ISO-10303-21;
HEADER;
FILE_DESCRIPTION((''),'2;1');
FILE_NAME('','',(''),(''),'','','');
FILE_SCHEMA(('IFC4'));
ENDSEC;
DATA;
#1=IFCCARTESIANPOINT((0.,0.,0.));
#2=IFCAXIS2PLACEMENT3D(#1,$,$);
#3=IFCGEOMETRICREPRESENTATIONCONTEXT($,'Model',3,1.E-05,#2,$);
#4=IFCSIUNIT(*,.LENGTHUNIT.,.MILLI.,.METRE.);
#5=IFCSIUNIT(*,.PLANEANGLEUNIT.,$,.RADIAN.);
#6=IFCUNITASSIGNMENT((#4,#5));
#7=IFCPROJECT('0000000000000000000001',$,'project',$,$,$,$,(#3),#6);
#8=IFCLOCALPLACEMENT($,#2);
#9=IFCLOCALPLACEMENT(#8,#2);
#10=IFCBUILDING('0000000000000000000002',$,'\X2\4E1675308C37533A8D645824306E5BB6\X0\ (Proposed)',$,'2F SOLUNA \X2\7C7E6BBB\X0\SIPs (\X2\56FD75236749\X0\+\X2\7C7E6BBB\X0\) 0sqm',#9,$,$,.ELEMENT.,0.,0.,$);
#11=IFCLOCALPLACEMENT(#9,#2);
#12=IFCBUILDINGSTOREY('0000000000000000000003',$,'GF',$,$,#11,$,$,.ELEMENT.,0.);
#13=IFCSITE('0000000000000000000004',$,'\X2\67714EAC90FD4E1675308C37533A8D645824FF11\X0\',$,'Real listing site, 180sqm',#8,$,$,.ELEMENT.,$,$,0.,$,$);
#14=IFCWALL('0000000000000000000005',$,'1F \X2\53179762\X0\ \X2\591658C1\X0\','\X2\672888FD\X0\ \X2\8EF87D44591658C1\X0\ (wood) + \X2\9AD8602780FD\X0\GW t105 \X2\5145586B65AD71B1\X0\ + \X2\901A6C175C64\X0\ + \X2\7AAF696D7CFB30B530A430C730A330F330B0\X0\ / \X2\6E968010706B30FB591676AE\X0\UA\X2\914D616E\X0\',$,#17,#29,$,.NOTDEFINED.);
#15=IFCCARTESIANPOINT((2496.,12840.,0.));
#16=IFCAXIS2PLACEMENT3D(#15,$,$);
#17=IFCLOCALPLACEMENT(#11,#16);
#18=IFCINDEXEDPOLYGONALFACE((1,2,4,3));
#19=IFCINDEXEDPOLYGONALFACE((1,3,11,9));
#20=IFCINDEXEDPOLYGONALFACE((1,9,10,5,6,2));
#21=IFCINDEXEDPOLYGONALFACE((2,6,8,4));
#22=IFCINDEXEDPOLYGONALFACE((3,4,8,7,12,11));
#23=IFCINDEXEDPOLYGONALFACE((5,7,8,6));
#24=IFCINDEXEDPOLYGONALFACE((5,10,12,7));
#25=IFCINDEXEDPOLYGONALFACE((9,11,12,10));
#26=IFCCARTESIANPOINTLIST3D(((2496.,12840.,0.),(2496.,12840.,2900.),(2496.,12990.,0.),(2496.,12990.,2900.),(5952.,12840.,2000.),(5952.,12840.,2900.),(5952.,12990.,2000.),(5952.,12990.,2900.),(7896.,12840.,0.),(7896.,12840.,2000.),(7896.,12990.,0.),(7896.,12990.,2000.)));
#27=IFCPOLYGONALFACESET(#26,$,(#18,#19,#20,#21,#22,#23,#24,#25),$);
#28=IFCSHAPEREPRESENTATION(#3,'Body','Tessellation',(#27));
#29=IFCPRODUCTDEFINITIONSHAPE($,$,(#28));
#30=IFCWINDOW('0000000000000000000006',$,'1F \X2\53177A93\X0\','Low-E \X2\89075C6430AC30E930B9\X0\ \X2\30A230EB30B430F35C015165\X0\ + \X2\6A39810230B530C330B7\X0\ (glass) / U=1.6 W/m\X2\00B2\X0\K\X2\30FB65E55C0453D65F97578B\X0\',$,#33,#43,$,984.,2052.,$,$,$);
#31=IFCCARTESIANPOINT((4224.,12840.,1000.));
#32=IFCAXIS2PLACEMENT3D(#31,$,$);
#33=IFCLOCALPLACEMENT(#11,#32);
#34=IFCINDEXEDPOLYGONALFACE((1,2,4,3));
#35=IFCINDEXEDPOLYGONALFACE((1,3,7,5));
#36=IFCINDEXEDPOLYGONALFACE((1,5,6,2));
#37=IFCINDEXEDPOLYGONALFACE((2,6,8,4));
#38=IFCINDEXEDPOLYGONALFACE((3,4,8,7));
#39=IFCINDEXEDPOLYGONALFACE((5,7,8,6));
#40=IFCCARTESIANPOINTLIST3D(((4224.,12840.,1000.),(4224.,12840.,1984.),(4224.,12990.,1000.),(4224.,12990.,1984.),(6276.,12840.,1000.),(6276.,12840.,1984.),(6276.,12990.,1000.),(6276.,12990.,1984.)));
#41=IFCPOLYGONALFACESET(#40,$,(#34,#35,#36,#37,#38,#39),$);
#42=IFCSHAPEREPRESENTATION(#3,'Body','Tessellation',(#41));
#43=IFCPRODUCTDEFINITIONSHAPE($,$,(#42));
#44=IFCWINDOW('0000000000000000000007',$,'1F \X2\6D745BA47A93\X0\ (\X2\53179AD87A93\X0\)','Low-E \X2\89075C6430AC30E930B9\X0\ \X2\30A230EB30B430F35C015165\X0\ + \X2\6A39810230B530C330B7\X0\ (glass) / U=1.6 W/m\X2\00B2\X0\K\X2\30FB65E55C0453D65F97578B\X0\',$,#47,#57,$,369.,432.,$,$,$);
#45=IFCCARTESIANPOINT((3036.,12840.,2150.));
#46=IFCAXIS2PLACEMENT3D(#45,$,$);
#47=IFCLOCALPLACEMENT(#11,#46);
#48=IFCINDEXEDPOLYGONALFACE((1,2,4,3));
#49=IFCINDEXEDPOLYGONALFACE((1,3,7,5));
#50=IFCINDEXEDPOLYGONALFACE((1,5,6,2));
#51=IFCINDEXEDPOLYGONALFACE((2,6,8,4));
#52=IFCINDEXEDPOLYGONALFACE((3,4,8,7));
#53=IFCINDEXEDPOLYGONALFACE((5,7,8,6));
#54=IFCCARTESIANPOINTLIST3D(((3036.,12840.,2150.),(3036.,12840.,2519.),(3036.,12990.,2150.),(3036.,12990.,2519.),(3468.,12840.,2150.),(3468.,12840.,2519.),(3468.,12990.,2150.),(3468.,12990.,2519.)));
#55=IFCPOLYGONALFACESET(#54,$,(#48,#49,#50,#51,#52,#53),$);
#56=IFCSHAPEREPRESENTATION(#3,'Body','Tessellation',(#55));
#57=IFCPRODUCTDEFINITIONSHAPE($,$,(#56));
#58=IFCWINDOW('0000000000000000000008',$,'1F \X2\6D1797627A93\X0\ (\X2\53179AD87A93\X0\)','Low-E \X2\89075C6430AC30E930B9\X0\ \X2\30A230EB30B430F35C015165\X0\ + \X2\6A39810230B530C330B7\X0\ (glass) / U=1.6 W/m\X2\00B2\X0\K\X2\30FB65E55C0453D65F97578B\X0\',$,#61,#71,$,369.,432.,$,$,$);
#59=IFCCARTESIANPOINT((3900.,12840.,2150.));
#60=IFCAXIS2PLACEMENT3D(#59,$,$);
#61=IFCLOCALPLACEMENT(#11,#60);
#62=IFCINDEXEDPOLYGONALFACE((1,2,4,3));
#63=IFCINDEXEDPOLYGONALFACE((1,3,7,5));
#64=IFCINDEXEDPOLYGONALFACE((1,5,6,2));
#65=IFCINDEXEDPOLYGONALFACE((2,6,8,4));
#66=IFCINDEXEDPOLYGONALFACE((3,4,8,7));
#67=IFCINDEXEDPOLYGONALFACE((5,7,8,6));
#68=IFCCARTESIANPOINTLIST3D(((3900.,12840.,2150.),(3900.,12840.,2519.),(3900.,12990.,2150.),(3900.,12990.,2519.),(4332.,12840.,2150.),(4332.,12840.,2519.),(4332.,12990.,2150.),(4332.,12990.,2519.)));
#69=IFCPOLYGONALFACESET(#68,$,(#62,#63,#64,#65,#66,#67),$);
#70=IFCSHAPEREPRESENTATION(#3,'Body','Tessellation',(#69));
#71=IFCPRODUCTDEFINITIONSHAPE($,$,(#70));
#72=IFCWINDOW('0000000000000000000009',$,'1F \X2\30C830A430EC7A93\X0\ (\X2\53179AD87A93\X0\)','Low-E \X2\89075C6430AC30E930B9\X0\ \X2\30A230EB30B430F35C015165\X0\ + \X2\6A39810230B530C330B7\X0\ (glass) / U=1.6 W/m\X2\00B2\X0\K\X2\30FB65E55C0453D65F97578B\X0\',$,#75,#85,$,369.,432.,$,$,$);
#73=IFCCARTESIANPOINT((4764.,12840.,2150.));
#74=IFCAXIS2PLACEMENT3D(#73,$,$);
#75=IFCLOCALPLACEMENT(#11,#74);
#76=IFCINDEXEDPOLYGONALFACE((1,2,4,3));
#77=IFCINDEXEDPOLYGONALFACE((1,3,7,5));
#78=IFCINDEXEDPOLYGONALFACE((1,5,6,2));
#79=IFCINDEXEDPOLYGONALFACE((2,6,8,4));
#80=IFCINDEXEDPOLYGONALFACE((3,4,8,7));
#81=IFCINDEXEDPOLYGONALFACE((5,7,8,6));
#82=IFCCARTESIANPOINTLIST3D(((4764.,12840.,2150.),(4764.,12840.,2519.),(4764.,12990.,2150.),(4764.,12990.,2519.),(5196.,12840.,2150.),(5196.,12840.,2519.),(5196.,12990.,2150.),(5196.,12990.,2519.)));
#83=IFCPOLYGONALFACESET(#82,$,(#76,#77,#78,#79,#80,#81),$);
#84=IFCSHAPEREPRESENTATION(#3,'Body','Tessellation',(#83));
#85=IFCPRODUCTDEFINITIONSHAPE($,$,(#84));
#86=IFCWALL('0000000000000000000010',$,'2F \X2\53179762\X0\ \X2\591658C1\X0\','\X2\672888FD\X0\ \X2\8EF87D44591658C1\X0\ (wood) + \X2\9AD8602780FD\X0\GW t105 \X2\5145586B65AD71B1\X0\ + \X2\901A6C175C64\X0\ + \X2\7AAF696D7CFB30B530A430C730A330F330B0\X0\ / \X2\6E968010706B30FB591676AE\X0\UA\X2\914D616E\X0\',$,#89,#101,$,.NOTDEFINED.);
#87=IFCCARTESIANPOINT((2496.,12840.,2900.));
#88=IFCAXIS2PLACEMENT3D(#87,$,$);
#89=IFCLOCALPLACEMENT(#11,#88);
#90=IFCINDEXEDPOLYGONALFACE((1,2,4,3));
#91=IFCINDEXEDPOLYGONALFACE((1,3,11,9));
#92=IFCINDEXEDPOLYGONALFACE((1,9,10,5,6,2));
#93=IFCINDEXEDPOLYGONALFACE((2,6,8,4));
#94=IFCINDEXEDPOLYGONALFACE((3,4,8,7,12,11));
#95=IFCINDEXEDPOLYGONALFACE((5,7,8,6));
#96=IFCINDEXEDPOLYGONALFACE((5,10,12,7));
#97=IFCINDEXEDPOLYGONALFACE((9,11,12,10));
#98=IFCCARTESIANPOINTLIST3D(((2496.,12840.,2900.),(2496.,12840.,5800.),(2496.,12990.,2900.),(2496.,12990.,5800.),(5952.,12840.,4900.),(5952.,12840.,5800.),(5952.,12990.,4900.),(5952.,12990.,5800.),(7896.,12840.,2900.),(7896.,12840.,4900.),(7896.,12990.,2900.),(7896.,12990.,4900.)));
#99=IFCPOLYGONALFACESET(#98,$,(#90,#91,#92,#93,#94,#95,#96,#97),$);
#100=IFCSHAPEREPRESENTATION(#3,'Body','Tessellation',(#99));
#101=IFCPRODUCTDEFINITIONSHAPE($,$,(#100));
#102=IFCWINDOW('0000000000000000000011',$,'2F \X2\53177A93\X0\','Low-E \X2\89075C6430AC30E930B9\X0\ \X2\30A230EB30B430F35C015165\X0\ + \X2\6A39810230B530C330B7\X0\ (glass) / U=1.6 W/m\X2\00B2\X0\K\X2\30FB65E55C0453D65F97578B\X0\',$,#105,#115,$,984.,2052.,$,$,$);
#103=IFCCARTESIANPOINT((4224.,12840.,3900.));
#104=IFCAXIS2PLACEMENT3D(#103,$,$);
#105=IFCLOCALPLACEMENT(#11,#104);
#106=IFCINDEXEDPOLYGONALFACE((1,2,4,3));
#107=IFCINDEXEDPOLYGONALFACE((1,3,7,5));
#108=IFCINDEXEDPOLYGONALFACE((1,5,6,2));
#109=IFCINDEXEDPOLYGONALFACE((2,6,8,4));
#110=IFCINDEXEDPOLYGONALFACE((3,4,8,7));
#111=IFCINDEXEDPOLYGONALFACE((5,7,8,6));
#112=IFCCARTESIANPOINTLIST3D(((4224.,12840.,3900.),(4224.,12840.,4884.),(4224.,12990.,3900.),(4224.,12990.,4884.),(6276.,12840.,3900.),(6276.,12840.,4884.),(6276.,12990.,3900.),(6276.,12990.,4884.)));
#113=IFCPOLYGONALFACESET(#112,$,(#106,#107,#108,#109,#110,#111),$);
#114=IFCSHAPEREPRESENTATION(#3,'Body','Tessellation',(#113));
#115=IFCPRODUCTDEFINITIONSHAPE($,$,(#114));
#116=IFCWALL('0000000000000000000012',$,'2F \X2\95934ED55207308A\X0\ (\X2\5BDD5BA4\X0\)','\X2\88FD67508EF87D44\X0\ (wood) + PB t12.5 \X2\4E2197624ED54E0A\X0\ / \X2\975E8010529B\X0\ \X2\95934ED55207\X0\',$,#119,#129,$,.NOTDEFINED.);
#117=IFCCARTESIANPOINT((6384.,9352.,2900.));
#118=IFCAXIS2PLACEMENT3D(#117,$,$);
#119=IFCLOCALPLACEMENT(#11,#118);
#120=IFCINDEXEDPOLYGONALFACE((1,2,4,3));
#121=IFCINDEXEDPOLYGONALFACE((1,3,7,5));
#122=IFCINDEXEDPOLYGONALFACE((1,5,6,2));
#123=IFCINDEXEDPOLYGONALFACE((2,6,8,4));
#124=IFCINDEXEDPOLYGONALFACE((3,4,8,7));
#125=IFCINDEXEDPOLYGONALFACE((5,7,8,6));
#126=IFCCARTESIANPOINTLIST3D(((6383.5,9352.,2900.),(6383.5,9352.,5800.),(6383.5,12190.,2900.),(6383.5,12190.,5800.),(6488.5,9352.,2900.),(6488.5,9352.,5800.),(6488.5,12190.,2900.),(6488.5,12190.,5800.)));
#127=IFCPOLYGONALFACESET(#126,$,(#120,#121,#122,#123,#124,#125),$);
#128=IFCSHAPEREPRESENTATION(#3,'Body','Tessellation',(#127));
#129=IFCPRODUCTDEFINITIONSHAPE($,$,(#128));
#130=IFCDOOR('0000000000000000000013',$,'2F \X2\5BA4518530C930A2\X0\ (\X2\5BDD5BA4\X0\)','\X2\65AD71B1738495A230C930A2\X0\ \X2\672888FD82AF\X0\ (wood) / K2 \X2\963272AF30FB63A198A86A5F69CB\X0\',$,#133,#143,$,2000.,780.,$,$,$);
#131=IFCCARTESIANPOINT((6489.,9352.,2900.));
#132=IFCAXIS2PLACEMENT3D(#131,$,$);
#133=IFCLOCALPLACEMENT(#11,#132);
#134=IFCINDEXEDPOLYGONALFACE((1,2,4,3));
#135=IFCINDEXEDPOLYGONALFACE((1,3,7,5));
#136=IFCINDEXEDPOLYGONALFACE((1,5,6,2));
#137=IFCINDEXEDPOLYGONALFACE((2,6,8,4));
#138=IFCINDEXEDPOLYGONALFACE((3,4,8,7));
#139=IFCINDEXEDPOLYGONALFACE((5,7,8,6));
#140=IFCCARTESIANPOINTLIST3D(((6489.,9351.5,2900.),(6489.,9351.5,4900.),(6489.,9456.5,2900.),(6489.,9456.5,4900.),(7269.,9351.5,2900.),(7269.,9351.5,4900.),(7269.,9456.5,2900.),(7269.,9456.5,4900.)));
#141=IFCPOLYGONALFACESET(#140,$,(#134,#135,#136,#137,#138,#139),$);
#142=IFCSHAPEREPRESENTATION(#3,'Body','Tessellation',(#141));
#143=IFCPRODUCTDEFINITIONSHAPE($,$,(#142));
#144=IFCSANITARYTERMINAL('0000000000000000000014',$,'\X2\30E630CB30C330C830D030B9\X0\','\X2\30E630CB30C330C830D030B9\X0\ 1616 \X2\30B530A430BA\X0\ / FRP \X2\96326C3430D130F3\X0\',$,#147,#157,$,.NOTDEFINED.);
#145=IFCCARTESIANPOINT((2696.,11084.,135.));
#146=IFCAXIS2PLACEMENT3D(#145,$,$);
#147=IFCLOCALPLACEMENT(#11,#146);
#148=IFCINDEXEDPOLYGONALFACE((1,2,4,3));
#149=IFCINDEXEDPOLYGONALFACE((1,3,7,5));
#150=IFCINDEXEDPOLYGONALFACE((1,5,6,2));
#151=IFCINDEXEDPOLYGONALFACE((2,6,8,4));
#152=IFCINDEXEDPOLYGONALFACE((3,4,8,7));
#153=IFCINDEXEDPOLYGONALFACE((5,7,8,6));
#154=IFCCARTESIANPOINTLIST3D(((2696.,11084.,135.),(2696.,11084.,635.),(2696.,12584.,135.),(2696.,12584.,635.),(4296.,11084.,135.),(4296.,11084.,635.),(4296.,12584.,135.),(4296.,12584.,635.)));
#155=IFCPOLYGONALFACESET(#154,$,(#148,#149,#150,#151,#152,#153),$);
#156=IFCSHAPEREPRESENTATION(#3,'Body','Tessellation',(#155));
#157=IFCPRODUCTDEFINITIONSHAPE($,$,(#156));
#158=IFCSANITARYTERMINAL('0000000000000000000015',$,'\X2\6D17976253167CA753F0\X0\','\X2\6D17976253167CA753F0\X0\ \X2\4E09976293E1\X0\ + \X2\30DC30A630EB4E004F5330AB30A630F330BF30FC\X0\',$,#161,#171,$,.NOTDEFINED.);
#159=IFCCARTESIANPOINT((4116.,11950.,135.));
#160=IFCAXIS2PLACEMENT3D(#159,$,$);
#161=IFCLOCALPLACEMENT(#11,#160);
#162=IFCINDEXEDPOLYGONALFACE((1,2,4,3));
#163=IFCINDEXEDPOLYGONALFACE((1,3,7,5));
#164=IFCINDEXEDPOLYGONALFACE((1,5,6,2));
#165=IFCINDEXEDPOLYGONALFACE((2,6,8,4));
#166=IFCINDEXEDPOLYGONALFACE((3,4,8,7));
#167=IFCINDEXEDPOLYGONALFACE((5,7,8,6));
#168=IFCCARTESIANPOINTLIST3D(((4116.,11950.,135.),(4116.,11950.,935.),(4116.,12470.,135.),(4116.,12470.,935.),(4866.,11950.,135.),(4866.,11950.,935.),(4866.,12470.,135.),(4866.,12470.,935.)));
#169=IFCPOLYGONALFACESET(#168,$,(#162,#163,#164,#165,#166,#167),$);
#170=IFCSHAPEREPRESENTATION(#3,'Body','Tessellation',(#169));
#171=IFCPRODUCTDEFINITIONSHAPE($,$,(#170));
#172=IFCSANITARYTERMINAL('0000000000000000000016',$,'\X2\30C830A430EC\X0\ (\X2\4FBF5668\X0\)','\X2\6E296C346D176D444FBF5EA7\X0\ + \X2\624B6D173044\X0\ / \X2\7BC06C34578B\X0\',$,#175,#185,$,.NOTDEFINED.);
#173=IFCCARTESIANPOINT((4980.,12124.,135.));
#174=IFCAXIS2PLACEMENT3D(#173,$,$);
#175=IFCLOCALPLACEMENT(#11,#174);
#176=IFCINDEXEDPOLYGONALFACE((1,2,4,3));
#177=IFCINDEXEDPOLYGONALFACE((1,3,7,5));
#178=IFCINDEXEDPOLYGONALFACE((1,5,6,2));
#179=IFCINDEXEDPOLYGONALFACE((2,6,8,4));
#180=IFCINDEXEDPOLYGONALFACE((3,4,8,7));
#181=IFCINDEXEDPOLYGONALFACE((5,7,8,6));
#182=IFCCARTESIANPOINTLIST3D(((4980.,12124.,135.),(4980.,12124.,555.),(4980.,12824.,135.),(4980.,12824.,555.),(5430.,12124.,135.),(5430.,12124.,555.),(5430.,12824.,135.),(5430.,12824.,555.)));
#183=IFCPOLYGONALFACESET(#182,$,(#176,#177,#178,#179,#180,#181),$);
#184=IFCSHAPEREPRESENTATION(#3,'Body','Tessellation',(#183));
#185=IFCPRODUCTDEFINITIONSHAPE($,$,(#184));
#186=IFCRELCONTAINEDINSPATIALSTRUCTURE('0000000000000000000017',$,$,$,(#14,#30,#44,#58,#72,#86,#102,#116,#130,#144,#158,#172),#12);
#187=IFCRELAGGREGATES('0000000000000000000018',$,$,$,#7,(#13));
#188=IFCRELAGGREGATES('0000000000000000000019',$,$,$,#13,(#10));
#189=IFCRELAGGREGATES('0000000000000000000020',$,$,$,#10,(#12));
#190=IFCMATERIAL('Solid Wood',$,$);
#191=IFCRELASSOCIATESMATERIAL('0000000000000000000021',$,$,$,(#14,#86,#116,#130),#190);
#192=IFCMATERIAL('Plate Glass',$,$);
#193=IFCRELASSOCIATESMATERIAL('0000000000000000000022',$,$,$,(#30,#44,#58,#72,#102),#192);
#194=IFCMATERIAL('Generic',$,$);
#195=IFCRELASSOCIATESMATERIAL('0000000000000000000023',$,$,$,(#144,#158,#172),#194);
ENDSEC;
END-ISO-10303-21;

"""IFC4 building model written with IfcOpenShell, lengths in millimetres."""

from ifc_helpers import new_model, si_unit, frame, frame_2d, origin, place, context, project, spatial, rectangle, extrude, material, element, fill, save


model = new_model("IFC4")

# Units and contexts
model_context = context("Model", 3, precision=1e-05, world=origin())
ifc_project = project(units=[si_unit("LENGTHUNIT", "METRE", prefix="MILLI"), si_unit("PLANEANGLEUNIT", "RADIAN")], contexts=[model_context])

# Site, building, storey
site_placement = place(None, origin())
site = spatial("IfcSite", under=ifc_project, at=site_placement, Name="東京都世田谷区赤堤１", ObjectType="Real listing site, 180sqm", CompositionType="ELEMENT", RefElevation=0.0)
building_placement = place(site_placement, origin())
building = spatial("IfcBuilding", under=site, at=building_placement, Name="世田谷区赤堤の家 (Proposed)", ObjectType="2F SOLUNA 籾殻SIPs (国産杉+籾殻) 0sqm", CompositionType="ELEMENT", ElevationOfRefHeight=0.0, ElevationOfTerrain=0.0)
storey_placement = place(building_placement, origin())
storey = spatial("IfcBuildingStorey", under=building, at=storey_placement, Name="GF", CompositionType="ELEMENT", Elevation=0.0)

# Wall, openings, windows
ifc_material_1 = material(Name="Solid Wood")
wall_1_placement = place(storey_placement, frame((2496.0, 12840.0, 0.0)))
wall_1 = element("IfcWall", 1, at=wall_1_placement, inside=storey, material=ifc_material_1, Name="1F 北面 外壁", Description="木製 軸組外壁 (wood) + 高性能GW t105 充填断熱 + 通気層 + 窯業系サイディング / 準耐火・外皮UA配慮", PredefinedType="NOTDEFINED", context=model_context, shape_type="SweptSolid", body=[
    extrude(rectangle(XDim=5400.0, YDim=150.0, at=frame_2d((2700.0, 75.0))), frame((2496.0, 12840.0, 0.0)), (0.0, 0.0, 1.0), 2900.0),
])
opening_1_placement = place(storey_placement, frame((4224.0, 12840.0, 1000.0)))
opening_1 = element("IfcOpeningElement", 2, at=opening_1_placement, cuts=wall_1, PredefinedType="NOTDEFINED", context=model_context, shape_type="SweptSolid", body=[
    extrude(rectangle(XDim=2052.0, YDim=150.0, at=frame_2d((1026.0, 75.0))), frame((4224.0, 12840.0, 1000.0)), (0.0, 0.0, 1.0), 984.0),
])
opening_2_placement = place(storey_placement, frame((3036.0, 12840.0, 2150.0)))
opening_2 = element("IfcOpeningElement", 3, at=opening_2_placement, cuts=wall_1, PredefinedType="NOTDEFINED", context=model_context, shape_type="SweptSolid", body=[
    extrude(rectangle(XDim=432.0, YDim=150.0, at=frame_2d((216.0, 75.0))), frame((3036.0, 12840.0, 2150.0)), (0.0, 0.0, 1.0), 369.0),
])
opening_3_placement = place(storey_placement, frame((3900.0, 12840.0, 2150.0)))
opening_3 = element("IfcOpeningElement", 4, at=opening_3_placement, cuts=wall_1, PredefinedType="NOTDEFINED", context=model_context, shape_type="SweptSolid", body=[
    extrude(rectangle(XDim=432.0, YDim=150.0, at=frame_2d((216.0, 75.0))), frame((3900.0, 12840.0, 2150.0)), (0.0, 0.0, 1.0), 369.0),
])
opening_4_placement = place(storey_placement, frame((4764.0, 12840.0, 2150.0)))
opening_4 = element("IfcOpeningElement", 5, at=opening_4_placement, cuts=wall_1, PredefinedType="NOTDEFINED", context=model_context, shape_type="SweptSolid", body=[
    extrude(rectangle(XDim=432.0, YDim=150.0, at=frame_2d((216.0, 75.0))), frame((4764.0, 12840.0, 2150.0)), (0.0, 0.0, 1.0), 369.0),
])
ifc_material_2 = material(Name="Plate Glass")
window_1_placement = place(storey_placement, frame((4224.0, 12840.0, 1000.0)))
window_1 = element("IfcWindow", 6, at=window_1_placement, inside=storey, material=ifc_material_2, Name="1F 北窓", Description="Low-E 複層ガラス アルゴン封入 + 樹脂サッシ (glass) / U=1.6 W/m²K・日射取得型", OverallHeight=984.0, OverallWidth=2052.0, context=model_context, shape_type="SweptSolid", body=[
    extrude(rectangle(XDim=2052.0, YDim=150.0, at=frame_2d((1026.0, 75.0))), frame((4224.0, 12840.0, 1000.0)), (0.0, 0.0, 1.0), 984.0),
])
fill(opening_1, window_1)
window_2_placement = place(storey_placement, frame((3036.0, 12840.0, 2150.0)))
window_2 = element("IfcWindow", 7, at=window_2_placement, inside=storey, material=ifc_material_2, Name="1F 浴室窓 (北高窓)", Description="Low-E 複層ガラス アルゴン封入 + 樹脂サッシ (glass) / U=1.6 W/m²K・日射取得型", OverallHeight=369.0, OverallWidth=432.0, context=model_context, shape_type="SweptSolid", body=[
    extrude(rectangle(XDim=432.0, YDim=150.0, at=frame_2d((216.0, 75.0))), frame((3036.0, 12840.0, 2150.0)), (0.0, 0.0, 1.0), 369.0),
])
fill(opening_2, window_2)
window_3_placement = place(storey_placement, frame((3900.0, 12840.0, 2150.0)))
window_3 = element("IfcWindow", 8, at=window_3_placement, inside=storey, material=ifc_material_2, Name="1F 洗面窓 (北高窓)", Description="Low-E 複層ガラス アルゴン封入 + 樹脂サッシ (glass) / U=1.6 W/m²K・日射取得型", OverallHeight=369.0, OverallWidth=432.0, context=model_context, shape_type="SweptSolid", body=[
    extrude(rectangle(XDim=432.0, YDim=150.0, at=frame_2d((216.0, 75.0))), frame((3900.0, 12840.0, 2150.0)), (0.0, 0.0, 1.0), 369.0),
])
fill(opening_3, window_3)
window_4_placement = place(storey_placement, frame((4764.0, 12840.0, 2150.0)))
window_4 = element("IfcWindow", 9, at=window_4_placement, inside=storey, material=ifc_material_2, Name="1F トイレ窓 (北高窓)", Description="Low-E 複層ガラス アルゴン封入 + 樹脂サッシ (glass) / U=1.6 W/m²K・日射取得型", OverallHeight=369.0, OverallWidth=432.0, context=model_context, shape_type="SweptSolid", body=[
    extrude(rectangle(XDim=432.0, YDim=150.0, at=frame_2d((216.0, 75.0))), frame((4764.0, 12840.0, 2150.0)), (0.0, 0.0, 1.0), 369.0),
])
fill(opening_4, window_4)

# Wall, opening, window
wall_2_placement = place(storey_placement, frame((2496.0, 12840.0, 2900.0)))
wall_2 = element("IfcWall", 10, at=wall_2_placement, inside=storey, material=ifc_material_1, Name="2F 北面 外壁", Description="木製 軸組外壁 (wood) + 高性能GW t105 充填断熱 + 通気層 + 窯業系サイディング / 準耐火・外皮UA配慮", PredefinedType="NOTDEFINED", context=model_context, shape_type="SweptSolid", body=[
    extrude(rectangle(XDim=5400.0, YDim=150.0, at=frame_2d((2700.0, 75.0))), frame((2496.0, 12840.0, 2900.0)), (0.0, 0.0, 1.0), 2900.0),
])
opening_5_placement = place(storey_placement, frame((4224.0, 12840.0, 3900.0)))
opening_5 = element("IfcOpeningElement", 11, at=opening_5_placement, cuts=wall_2, PredefinedType="NOTDEFINED", context=model_context, shape_type="SweptSolid", body=[
    extrude(rectangle(XDim=2052.0, YDim=150.0, at=frame_2d((1026.0, 75.0))), frame((4224.0, 12840.0, 3900.0)), (0.0, 0.0, 1.0), 984.0),
])
window_5_placement = place(storey_placement, frame((4224.0, 12840.0, 3900.0)))
window_5 = element("IfcWindow", 12, at=window_5_placement, inside=storey, material=ifc_material_2, Name="2F 北窓", Description="Low-E 複層ガラス アルゴン封入 + 樹脂サッシ (glass) / U=1.6 W/m²K・日射取得型", OverallHeight=984.0, OverallWidth=2052.0, context=model_context, shape_type="SweptSolid", body=[
    extrude(rectangle(XDim=2052.0, YDim=150.0, at=frame_2d((1026.0, 75.0))), frame((4224.0, 12840.0, 3900.0)), (0.0, 0.0, 1.0), 984.0),
])
fill(opening_5, window_5)

# Wall
wall_3_placement = place(storey_placement, frame((6384.0, 9352.0, 2900.0)))
element("IfcWall", 13, at=wall_3_placement, inside=storey, material=ifc_material_1, Name="2F 間仕切り (寝室)", Description="製材軸組 (wood) + PB t12.5 両面仕上 / 非耐力 間仕切", PredefinedType="NOTDEFINED", context=model_context, shape_type="SweptSolid", body=[
    extrude(rectangle(XDim=105.0, YDim=2838.0, at=frame_2d((52.0, 1419.0))), frame((6384.0, 9352.0, 2900.0)), (0.0, 0.0, 1.0), 2900.0),
])

# Door
door_1_placement = place(storey_placement, frame((6489.0, 9352.0, 2900.0)))
element("IfcDoor", 14, at=door_1_placement, inside=storey, material=ifc_material_1, Name="2F 室内ドア (寝室)", Description="断熱玄関ドア 木製芯 (wood) / K2 防犯・採風機構", OverallHeight=2000.0, OverallWidth=780.0, context=model_context, shape_type="SweptSolid", body=[
    extrude(rectangle(XDim=780.0, YDim=105.0, at=frame_2d((390.0, 52.0))), frame((6489.0, 9352.0, 2900.0)), (0.0, 0.0, 1.0), 2000.0),
])

# Sanitary terminals
ifc_material_3 = material(Name="Generic")
sanitary_terminal_1_placement = place(storey_placement, frame((2696.0, 11084.0, 135.0)))
element("IfcSanitaryTerminal", 15, at=sanitary_terminal_1_placement, inside=storey, material=ifc_material_3, Name="ユニットバス", Description="ユニットバス 1616 サイズ / FRP 防水パン", PredefinedType="NOTDEFINED", context=model_context, shape_type="SweptSolid", body=[
    extrude(rectangle(XDim=1600.0, YDim=1500.0, at=frame_2d((800.0, 750.0))), frame((2696.0, 11084.0, 135.0)), (0.0, 0.0, 1.0), 500.0),
])
sanitary_terminal_2_placement = place(storey_placement, frame((4116.0, 11950.0, 135.0)))
element("IfcSanitaryTerminal", 16, at=sanitary_terminal_2_placement, inside=storey, material=ifc_material_3, Name="洗面化粧台", Description="洗面化粧台 三面鏡 + ボウル一体カウンター", PredefinedType="NOTDEFINED", context=model_context, shape_type="SweptSolid", body=[
    extrude(rectangle(XDim=750.0, YDim=520.0, at=frame_2d((375.0, 260.0))), frame((4116.0, 11950.0, 135.0)), (0.0, 0.0, 1.0), 800.0),
])
sanitary_terminal_3_placement = place(storey_placement, frame((4980.0, 12124.0, 135.0)))
element("IfcSanitaryTerminal", 17, at=sanitary_terminal_3_placement, inside=storey, material=ifc_material_3, Name="トイレ (便器)", Description="温水洗浄便座 + 手洗い / 節水型", PredefinedType="NOTDEFINED", context=model_context, shape_type="SweptSolid", body=[
    extrude(rectangle(XDim=450.0, YDim=700.0, at=frame_2d((225.0, 350.0))), frame((4980.0, 12124.0, 135.0)), (0.0, 0.0, 1.0), 420.0),
])

save(model, "model.ifc")
